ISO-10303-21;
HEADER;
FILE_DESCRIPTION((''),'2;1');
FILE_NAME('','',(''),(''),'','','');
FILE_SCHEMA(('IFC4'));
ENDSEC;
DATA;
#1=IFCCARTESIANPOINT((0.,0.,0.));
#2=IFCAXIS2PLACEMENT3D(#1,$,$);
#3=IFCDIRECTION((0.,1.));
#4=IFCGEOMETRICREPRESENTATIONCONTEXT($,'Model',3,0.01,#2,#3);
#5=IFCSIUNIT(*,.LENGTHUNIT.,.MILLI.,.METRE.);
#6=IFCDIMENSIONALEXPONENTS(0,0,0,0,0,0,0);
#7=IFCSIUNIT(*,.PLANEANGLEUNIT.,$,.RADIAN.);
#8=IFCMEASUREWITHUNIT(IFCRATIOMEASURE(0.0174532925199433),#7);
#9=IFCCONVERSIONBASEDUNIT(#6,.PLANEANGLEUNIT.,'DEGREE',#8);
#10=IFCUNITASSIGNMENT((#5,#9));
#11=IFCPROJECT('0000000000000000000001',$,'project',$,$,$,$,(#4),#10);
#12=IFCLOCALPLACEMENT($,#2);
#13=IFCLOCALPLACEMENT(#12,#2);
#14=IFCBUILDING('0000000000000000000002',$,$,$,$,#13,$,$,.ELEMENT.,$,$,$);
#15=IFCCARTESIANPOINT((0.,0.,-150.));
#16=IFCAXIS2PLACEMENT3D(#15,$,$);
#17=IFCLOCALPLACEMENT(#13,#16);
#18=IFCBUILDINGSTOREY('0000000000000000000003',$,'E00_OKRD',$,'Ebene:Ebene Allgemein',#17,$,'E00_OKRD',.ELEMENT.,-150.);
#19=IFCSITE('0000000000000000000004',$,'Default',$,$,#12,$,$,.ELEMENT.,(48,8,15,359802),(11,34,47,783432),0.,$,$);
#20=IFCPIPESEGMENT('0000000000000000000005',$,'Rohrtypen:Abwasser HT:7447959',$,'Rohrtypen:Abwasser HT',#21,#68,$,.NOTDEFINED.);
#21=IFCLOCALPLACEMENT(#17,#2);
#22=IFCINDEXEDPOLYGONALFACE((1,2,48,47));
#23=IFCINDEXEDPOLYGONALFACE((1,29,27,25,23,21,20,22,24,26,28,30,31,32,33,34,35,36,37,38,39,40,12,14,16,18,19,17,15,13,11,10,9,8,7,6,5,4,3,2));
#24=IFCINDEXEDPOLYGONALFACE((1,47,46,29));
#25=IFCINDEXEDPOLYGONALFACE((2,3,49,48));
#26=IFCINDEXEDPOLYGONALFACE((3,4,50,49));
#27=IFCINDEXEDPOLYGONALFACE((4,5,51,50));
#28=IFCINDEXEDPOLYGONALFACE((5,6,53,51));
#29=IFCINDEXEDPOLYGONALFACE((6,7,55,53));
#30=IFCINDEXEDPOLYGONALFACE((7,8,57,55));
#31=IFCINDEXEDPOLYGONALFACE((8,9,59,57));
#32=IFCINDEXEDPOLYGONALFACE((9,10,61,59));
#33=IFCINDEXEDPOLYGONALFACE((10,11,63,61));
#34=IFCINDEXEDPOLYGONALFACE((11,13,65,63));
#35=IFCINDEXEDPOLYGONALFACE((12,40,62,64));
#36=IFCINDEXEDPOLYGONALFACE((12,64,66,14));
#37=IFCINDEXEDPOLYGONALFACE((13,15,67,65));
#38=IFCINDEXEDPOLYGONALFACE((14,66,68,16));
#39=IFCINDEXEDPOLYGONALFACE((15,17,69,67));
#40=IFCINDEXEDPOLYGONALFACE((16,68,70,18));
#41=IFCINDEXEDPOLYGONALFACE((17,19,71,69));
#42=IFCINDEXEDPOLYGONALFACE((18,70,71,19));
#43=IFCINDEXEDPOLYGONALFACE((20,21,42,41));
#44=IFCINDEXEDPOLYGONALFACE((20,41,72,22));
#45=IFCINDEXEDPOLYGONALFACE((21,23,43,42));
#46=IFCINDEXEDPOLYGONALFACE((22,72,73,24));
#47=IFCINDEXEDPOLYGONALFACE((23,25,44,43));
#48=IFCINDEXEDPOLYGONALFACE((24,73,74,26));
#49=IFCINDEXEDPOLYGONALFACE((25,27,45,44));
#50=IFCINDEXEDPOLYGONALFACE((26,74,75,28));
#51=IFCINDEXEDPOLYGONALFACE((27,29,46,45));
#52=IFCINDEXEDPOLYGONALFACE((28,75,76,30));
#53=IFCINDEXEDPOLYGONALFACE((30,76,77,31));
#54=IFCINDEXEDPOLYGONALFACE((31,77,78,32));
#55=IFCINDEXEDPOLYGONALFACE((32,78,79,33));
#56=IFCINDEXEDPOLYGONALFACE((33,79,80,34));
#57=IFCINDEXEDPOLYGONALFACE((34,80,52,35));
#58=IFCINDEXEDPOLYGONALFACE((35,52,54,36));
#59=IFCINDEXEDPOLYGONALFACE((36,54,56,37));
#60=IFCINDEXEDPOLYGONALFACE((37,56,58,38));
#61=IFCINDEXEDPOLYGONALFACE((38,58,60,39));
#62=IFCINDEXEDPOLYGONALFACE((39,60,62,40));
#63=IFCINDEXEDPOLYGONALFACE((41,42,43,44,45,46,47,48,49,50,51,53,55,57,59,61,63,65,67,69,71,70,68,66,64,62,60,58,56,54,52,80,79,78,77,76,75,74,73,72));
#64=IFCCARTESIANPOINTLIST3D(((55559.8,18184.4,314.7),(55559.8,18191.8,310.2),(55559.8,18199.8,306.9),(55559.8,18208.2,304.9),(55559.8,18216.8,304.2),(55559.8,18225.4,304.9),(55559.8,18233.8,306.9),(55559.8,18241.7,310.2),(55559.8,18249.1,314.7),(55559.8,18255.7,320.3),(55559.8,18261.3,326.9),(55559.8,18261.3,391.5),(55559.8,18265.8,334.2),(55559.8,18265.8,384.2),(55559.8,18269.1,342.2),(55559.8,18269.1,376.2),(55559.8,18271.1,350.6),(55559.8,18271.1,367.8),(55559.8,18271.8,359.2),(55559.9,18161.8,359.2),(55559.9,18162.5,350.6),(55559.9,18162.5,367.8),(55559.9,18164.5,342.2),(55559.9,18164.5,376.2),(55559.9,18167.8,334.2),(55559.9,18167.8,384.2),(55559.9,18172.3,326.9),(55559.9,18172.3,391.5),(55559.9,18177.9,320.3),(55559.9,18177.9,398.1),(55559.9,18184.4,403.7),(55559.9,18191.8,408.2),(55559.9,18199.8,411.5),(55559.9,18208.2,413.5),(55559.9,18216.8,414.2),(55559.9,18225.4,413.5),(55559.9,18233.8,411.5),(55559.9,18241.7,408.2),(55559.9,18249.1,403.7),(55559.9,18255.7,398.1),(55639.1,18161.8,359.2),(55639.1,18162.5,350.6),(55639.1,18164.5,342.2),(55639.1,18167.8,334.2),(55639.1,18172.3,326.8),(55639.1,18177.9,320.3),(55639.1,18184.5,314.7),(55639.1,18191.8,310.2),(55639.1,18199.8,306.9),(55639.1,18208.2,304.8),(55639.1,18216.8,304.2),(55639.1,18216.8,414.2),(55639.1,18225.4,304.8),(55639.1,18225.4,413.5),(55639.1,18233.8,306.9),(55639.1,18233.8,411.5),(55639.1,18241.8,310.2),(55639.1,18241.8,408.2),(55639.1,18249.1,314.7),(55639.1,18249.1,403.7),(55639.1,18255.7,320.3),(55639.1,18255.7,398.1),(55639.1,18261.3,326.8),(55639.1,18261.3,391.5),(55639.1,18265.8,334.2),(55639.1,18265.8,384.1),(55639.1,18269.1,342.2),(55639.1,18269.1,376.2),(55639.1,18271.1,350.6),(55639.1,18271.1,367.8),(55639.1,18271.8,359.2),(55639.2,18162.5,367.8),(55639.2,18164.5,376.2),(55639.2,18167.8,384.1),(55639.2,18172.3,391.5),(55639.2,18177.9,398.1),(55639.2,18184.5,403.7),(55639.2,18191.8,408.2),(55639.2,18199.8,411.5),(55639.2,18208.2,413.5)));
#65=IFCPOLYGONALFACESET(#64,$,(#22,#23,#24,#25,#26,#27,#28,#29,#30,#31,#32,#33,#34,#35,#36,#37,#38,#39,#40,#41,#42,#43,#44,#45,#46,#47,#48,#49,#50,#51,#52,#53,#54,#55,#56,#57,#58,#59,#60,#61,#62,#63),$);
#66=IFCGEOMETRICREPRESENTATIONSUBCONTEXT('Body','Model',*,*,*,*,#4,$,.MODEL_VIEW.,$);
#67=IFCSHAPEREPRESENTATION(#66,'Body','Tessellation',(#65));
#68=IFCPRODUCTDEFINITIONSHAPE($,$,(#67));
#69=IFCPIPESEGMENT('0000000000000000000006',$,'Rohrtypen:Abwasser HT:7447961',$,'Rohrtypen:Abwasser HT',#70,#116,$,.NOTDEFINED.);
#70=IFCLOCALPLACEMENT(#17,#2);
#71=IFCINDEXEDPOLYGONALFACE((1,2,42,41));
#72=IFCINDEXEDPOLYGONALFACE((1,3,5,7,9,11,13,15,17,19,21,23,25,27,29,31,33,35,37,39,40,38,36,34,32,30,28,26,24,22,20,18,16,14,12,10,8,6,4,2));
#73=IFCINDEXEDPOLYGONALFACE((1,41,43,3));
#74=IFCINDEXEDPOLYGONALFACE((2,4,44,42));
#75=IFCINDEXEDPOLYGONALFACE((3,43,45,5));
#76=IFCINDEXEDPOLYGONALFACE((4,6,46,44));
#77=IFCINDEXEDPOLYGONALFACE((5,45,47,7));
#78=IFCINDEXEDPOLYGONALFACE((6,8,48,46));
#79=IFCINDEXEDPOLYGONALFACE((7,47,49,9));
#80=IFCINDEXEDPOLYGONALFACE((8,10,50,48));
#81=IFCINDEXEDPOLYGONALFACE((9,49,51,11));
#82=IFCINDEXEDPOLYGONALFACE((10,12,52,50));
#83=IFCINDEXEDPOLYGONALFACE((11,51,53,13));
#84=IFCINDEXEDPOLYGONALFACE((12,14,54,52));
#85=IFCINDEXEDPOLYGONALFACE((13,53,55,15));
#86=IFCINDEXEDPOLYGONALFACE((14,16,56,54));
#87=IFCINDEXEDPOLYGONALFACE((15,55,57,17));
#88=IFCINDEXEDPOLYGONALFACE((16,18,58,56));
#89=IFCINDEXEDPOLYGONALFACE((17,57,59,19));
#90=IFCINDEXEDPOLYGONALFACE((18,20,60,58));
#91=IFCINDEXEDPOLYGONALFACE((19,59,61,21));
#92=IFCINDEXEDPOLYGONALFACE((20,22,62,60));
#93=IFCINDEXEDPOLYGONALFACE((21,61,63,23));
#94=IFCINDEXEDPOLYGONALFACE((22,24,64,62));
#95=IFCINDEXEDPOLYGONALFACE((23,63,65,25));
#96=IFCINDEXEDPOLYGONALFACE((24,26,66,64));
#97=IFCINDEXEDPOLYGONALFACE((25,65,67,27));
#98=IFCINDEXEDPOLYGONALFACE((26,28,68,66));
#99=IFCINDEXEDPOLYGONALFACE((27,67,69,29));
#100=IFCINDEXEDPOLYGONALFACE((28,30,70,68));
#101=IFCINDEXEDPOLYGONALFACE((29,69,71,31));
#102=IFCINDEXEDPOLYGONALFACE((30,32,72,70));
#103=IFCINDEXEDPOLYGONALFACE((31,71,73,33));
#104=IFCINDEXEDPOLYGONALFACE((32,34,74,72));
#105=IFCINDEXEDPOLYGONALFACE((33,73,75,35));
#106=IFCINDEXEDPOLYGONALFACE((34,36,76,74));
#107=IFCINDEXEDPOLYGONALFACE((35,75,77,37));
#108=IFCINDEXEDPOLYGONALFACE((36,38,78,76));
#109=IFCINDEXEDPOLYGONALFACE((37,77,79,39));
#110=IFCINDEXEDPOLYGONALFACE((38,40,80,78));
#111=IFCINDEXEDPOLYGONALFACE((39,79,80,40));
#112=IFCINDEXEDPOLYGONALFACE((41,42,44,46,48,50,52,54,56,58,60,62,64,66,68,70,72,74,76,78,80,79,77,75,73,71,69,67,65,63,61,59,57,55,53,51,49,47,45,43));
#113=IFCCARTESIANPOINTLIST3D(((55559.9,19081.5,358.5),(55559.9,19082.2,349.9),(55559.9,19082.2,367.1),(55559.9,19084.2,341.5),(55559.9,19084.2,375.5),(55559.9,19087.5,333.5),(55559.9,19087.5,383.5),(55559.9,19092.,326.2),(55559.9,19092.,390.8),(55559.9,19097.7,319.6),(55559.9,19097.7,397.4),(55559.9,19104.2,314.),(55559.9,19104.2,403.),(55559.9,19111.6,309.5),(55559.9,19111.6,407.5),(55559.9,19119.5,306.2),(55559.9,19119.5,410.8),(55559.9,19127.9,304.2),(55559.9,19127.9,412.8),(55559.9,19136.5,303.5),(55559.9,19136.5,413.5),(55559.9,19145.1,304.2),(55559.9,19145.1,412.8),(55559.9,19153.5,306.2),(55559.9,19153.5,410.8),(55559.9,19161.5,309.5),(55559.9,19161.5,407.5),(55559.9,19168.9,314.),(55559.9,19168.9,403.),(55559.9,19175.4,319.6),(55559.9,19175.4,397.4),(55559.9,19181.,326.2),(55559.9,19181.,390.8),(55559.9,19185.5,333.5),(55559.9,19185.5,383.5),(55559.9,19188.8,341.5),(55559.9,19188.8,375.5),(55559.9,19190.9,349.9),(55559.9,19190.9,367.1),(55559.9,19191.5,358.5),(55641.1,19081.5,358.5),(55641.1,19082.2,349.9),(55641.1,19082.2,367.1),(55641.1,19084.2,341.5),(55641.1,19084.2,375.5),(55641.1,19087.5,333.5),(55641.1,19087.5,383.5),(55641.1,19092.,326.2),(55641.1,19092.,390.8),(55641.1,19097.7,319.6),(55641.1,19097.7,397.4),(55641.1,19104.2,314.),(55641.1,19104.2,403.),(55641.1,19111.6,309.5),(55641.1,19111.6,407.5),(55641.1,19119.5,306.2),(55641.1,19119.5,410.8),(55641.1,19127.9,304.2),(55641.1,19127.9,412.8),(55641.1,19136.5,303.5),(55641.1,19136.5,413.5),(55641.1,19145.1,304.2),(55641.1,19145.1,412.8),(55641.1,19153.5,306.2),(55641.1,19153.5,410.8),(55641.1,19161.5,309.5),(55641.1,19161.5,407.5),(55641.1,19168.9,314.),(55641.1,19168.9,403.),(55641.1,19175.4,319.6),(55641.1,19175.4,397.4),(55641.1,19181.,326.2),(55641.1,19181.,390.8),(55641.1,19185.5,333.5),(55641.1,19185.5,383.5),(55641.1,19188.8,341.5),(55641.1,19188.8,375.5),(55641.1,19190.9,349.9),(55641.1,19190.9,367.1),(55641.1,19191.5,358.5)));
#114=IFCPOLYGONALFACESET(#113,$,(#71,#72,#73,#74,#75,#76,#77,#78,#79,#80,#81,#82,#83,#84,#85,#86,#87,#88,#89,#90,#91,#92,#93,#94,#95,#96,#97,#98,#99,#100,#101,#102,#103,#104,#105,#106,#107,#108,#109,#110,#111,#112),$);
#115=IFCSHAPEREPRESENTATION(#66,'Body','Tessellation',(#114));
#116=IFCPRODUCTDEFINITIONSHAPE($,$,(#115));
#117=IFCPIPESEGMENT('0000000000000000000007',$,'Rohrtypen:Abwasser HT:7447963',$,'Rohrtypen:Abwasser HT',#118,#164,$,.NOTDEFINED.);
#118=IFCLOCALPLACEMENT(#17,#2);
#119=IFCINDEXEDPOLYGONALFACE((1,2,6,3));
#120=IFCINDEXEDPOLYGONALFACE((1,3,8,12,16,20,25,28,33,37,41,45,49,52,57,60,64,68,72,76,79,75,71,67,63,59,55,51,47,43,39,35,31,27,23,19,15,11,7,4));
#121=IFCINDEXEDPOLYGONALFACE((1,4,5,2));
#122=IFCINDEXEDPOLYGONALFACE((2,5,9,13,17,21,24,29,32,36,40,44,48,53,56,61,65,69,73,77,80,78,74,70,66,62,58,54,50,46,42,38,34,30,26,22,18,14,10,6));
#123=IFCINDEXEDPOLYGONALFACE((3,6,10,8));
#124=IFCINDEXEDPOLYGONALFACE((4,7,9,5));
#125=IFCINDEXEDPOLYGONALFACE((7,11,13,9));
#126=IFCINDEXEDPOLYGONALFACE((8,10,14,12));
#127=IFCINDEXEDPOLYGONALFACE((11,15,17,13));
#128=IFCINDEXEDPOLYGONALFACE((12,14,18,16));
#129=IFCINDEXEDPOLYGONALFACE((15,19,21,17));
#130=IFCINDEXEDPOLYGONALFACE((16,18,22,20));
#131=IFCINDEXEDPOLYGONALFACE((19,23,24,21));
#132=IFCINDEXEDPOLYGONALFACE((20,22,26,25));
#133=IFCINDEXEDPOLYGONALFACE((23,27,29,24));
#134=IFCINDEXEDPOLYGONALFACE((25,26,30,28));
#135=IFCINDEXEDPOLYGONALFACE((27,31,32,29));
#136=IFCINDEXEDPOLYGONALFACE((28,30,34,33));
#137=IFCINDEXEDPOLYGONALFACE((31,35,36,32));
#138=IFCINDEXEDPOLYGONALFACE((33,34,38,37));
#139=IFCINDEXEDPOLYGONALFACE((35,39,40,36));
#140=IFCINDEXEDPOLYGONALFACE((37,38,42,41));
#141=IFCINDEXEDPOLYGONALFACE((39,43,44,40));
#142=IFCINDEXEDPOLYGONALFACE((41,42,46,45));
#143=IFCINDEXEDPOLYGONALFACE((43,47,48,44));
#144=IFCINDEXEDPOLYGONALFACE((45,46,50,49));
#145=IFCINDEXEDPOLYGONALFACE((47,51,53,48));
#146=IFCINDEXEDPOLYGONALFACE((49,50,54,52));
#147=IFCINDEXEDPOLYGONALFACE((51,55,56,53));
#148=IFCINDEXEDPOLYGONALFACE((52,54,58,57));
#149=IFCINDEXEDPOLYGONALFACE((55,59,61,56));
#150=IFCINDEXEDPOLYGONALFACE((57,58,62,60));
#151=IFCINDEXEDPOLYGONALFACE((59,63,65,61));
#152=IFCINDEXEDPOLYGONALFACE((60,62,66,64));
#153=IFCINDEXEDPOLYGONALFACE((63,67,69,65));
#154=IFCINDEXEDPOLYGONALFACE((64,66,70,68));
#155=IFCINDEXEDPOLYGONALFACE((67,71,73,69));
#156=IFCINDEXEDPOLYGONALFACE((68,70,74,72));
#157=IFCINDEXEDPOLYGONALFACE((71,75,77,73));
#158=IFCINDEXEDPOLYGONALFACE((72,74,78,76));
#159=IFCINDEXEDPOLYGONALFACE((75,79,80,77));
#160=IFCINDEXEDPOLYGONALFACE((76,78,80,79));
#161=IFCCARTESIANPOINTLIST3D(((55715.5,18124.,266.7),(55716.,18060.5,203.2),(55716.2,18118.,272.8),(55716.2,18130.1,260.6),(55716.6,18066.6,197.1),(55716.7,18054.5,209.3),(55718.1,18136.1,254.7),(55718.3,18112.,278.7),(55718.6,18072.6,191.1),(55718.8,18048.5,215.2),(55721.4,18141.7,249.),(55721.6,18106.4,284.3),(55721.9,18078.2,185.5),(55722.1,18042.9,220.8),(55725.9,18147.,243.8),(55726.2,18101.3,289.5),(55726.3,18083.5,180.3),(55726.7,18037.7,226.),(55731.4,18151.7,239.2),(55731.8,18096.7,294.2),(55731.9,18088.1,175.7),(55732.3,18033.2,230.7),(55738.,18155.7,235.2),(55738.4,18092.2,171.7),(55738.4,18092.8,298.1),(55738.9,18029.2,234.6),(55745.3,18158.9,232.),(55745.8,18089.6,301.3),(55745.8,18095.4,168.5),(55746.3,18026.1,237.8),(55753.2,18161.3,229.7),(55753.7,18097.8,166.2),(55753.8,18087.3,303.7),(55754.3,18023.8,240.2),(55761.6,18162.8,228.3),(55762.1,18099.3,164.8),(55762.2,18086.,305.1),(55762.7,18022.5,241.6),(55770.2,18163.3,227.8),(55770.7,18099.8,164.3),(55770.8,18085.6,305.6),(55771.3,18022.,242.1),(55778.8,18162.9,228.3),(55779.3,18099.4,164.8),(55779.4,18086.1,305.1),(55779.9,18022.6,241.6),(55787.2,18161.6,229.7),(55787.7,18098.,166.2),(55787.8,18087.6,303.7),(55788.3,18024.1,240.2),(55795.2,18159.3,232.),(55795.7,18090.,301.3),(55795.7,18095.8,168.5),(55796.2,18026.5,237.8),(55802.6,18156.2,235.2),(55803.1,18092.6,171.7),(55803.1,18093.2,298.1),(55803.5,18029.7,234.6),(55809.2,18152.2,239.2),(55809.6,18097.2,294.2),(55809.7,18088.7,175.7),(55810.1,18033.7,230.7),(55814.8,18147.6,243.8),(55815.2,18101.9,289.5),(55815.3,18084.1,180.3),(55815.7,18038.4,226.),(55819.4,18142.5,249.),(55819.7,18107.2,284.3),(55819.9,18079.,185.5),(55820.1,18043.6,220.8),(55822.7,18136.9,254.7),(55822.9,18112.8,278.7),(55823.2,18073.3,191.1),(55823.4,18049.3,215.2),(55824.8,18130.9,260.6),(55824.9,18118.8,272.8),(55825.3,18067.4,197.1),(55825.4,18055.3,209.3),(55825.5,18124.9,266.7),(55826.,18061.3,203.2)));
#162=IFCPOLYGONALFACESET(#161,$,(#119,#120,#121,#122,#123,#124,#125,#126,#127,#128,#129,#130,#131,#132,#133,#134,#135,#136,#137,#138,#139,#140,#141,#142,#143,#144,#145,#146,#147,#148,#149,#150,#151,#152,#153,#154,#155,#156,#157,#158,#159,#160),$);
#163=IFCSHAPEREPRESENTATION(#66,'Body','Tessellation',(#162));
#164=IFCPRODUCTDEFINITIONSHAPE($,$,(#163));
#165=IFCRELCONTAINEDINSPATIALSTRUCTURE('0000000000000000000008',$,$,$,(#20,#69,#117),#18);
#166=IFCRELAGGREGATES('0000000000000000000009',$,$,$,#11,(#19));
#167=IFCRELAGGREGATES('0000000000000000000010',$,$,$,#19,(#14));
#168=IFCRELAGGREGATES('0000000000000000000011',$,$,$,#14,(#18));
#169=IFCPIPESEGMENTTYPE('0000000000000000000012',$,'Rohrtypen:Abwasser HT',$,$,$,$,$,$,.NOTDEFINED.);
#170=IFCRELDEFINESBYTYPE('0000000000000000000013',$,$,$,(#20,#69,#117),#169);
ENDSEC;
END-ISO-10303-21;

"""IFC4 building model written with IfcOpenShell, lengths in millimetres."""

from ifc_helpers import new_model, entity, si_unit, converted_unit, direction, frame, origin, place, context, subcontext, project, spatial, indexed_curve, outline, extrude, type_object, element, save


model = new_model("IFC4")

# Units and contexts
model_context = context("Model", 3, precision=0.01, world=origin(), true_north=direction((0.0, 1.0)))
body_context = subcontext(model_context, "Body", "Model", "MODEL_VIEW")
ifc_project = project(units=[si_unit("LENGTHUNIT", "METRE", prefix="MILLI"), converted_unit("PLANEANGLEUNIT", "DEGREE", entity("IfcRatioMeasure", 0.0174532925199433), si_unit("PLANEANGLEUNIT", "RADIAN"), dimensions=[0, 0, 0, 0, 0, 0, 0])], contexts=[model_context])

# Site, building, storey
site_placement = place(None, origin())
site = spatial("IfcSite", under=ifc_project, at=site_placement, Name="Default", CompositionType="ELEMENT", RefLatitude=(48, 8, 15, 359802), RefLongitude=(11, 34, 47, 783432), RefElevation=0.0)
building_placement = place(site_placement, origin())
building = spatial("IfcBuilding", under=site, at=building_placement, CompositionType="ELEMENT")
storey_placement = place(building_placement, frame((0.0, 0.0, -150.0)))
storey = spatial("IfcBuildingStorey", under=building, at=storey_placement, Name="E00_OKRD", ObjectType="Ebene:Ebene Allgemein", LongName="E00_OKRD", CompositionType="ELEMENT", Elevation=-150.0)

# Pipe segments
pipe_segment_type_1 = type_object("IfcPipeSegmentType", Name="Rohrtypen:Abwasser HT", PredefinedType="NOTDEFINED")
pipe_segment_1_placement = place(storey_placement, origin())
element("IfcPipeSegment", 1, at=pipe_segment_1_placement, inside=storey, type_object=pipe_segment_type_1, Name="Rohrtypen:Abwasser HT:7447959", ObjectType="Rohrtypen:Abwasser HT", PredefinedType="NOTDEFINED", context=body_context, shape_type="SweptSolid", body=[
    extrude(outline(indexed_curve([(55.0, 0.0), (54.3, 8.6), (52.3, 17.0), (49.0, 25.0), (44.5, 32.3), (38.9, 38.9), (32.3, 44.5), (25.0, 49.0), (17.0, 52.3), (8.6, 54.3), (0.0, 55.0), (-8.6, 54.3), (-17.0, 52.3), (-25.0, 49.0), (-32.3, 44.5), (-38.9, 38.9), (-44.5, 32.3), (-49.0, 25.0), (-52.3, 17.0), (-54.3, 8.6), (-55.0, 0.0), (-54.3, -8.6), (-52.3, -17.0), (-49.0, -25.0), (-44.5, -32.3), (-38.9, -38.9), (-32.3, -44.5), (-25.0, -49.0), (-17.0, -52.3), (-8.6, -54.3), (0.0, -55.0), (8.6, -54.3), (17.0, -52.3), (25.0, -49.0), (32.3, -44.5), (38.9, -38.9), (44.5, -32.3), (49.0, -25.0), (52.3, -17.0), (54.3, -8.6), (55.0, 0.0)], self_intersect=False)), frame((55639.1, 18216.8, 359.2), z_axis=(-1.0, -0.000427, 0.000427), x_axis=(0.000427, -1.0, 0.0)), (0.0, 0.0, 1.0), 79.3),
])
pipe_segment_2_placement = place(storey_placement, origin())
element("IfcPipeSegment", 2, at=pipe_segment_2_placement, inside=storey, type_object=pipe_segment_type_1, Name="Rohrtypen:Abwasser HT:7447961", ObjectType="Rohrtypen:Abwasser HT", PredefinedType="NOTDEFINED", context=body_context, shape_type="SweptSolid", body=[
    extrude(outline(indexed_curve([(55.0, 0.0), (54.3, 8.6), (52.3, 17.0), (49.0, 25.0), (44.5, 32.3), (38.9, 38.9), (32.3, 44.5), (25.0, 49.0), (17.0, 52.3), (8.6, 54.3), (0.0, 55.0), (-8.6, 54.3), (-17.0, 52.3), (-25.0, 49.0), (-32.3, 44.5), (-38.9, 38.9), (-44.5, 32.3), (-49.0, 25.0), (-52.3, 17.0), (-54.3, 8.6), (-55.0, 0.0), (-54.3, -8.6), (-52.3, -17.0), (-49.0, -25.0), (-44.5, -32.3), (-38.9, -38.9), (-32.3, -44.5), (-25.0, -49.0), (-17.0, -52.3), (-8.6, -54.3), (0.0, -55.0), (8.6, -54.3), (17.0, -52.3), (25.0, -49.0), (32.3, -44.5), (38.9, -38.9), (44.5, -32.3), (49.0, -25.0), (52.3, -17.0), (54.3, -8.6), (55.0, 0.0)], self_intersect=False)), frame((55559.9, 19136.5, 358.5), z_axis=(1.0, 0.0, 0.0), x_axis=(0.0, -1.0, 0.0)), (0.0, 0.0, 1.0), 81.3),
])
pipe_segment_3_placement = place(storey_placement, origin())
element("IfcPipeSegment", 3, at=pipe_segment_3_placement, inside=storey, type_object=pipe_segment_type_1, Name="Rohrtypen:Abwasser HT:7447963", ObjectType="Rohrtypen:Abwasser HT", PredefinedType="NOTDEFINED", context=body_context, shape_type="SweptSolid", body=[
    extrude(outline(indexed_curve([(55.0, 0.0), (54.3, 8.6), (52.3, 17.0), (49.0, 25.0), (44.5, 32.3), (38.9, 38.9), (32.3, 44.5), (25.0, 49.0), (17.0, 52.3), (8.6, 54.3), (0.0, 55.0), (-8.6, 54.3), (-17.0, 52.3), (-25.0, 49.0), (-32.3, 44.5), (-38.9, 38.9), (-44.5, 32.3), (-49.0, 25.0), (-52.3, 17.0), (-54.3, 8.6), (-55.0, 0.0), (-54.3, -8.6), (-52.3, -17.0), (-49.0, -25.0), (-44.5, -32.3), (-38.9, -38.9), (-32.3, -44.5), (-25.0, -49.0), (-17.0, -52.3), (-8.6, -54.3), (0.0, -55.0), (8.6, -54.3), (17.0, -52.3), (25.0, -49.0), (32.3, -44.5), (38.9, -38.9), (44.5, -32.3), (49.0, -25.0), (52.3, -17.0), (54.3, -8.6), (55.0, 0.0)], self_intersect=False)), frame((55771.0, 18060.9, 203.2), z_axis=(-0.005242, 0.707101, 0.707093), x_axis=(-0.999973, -0.007413, 0.0)), (0.0, 0.0, 1.0), 89.8),
])

save(model, "model.ifc")
